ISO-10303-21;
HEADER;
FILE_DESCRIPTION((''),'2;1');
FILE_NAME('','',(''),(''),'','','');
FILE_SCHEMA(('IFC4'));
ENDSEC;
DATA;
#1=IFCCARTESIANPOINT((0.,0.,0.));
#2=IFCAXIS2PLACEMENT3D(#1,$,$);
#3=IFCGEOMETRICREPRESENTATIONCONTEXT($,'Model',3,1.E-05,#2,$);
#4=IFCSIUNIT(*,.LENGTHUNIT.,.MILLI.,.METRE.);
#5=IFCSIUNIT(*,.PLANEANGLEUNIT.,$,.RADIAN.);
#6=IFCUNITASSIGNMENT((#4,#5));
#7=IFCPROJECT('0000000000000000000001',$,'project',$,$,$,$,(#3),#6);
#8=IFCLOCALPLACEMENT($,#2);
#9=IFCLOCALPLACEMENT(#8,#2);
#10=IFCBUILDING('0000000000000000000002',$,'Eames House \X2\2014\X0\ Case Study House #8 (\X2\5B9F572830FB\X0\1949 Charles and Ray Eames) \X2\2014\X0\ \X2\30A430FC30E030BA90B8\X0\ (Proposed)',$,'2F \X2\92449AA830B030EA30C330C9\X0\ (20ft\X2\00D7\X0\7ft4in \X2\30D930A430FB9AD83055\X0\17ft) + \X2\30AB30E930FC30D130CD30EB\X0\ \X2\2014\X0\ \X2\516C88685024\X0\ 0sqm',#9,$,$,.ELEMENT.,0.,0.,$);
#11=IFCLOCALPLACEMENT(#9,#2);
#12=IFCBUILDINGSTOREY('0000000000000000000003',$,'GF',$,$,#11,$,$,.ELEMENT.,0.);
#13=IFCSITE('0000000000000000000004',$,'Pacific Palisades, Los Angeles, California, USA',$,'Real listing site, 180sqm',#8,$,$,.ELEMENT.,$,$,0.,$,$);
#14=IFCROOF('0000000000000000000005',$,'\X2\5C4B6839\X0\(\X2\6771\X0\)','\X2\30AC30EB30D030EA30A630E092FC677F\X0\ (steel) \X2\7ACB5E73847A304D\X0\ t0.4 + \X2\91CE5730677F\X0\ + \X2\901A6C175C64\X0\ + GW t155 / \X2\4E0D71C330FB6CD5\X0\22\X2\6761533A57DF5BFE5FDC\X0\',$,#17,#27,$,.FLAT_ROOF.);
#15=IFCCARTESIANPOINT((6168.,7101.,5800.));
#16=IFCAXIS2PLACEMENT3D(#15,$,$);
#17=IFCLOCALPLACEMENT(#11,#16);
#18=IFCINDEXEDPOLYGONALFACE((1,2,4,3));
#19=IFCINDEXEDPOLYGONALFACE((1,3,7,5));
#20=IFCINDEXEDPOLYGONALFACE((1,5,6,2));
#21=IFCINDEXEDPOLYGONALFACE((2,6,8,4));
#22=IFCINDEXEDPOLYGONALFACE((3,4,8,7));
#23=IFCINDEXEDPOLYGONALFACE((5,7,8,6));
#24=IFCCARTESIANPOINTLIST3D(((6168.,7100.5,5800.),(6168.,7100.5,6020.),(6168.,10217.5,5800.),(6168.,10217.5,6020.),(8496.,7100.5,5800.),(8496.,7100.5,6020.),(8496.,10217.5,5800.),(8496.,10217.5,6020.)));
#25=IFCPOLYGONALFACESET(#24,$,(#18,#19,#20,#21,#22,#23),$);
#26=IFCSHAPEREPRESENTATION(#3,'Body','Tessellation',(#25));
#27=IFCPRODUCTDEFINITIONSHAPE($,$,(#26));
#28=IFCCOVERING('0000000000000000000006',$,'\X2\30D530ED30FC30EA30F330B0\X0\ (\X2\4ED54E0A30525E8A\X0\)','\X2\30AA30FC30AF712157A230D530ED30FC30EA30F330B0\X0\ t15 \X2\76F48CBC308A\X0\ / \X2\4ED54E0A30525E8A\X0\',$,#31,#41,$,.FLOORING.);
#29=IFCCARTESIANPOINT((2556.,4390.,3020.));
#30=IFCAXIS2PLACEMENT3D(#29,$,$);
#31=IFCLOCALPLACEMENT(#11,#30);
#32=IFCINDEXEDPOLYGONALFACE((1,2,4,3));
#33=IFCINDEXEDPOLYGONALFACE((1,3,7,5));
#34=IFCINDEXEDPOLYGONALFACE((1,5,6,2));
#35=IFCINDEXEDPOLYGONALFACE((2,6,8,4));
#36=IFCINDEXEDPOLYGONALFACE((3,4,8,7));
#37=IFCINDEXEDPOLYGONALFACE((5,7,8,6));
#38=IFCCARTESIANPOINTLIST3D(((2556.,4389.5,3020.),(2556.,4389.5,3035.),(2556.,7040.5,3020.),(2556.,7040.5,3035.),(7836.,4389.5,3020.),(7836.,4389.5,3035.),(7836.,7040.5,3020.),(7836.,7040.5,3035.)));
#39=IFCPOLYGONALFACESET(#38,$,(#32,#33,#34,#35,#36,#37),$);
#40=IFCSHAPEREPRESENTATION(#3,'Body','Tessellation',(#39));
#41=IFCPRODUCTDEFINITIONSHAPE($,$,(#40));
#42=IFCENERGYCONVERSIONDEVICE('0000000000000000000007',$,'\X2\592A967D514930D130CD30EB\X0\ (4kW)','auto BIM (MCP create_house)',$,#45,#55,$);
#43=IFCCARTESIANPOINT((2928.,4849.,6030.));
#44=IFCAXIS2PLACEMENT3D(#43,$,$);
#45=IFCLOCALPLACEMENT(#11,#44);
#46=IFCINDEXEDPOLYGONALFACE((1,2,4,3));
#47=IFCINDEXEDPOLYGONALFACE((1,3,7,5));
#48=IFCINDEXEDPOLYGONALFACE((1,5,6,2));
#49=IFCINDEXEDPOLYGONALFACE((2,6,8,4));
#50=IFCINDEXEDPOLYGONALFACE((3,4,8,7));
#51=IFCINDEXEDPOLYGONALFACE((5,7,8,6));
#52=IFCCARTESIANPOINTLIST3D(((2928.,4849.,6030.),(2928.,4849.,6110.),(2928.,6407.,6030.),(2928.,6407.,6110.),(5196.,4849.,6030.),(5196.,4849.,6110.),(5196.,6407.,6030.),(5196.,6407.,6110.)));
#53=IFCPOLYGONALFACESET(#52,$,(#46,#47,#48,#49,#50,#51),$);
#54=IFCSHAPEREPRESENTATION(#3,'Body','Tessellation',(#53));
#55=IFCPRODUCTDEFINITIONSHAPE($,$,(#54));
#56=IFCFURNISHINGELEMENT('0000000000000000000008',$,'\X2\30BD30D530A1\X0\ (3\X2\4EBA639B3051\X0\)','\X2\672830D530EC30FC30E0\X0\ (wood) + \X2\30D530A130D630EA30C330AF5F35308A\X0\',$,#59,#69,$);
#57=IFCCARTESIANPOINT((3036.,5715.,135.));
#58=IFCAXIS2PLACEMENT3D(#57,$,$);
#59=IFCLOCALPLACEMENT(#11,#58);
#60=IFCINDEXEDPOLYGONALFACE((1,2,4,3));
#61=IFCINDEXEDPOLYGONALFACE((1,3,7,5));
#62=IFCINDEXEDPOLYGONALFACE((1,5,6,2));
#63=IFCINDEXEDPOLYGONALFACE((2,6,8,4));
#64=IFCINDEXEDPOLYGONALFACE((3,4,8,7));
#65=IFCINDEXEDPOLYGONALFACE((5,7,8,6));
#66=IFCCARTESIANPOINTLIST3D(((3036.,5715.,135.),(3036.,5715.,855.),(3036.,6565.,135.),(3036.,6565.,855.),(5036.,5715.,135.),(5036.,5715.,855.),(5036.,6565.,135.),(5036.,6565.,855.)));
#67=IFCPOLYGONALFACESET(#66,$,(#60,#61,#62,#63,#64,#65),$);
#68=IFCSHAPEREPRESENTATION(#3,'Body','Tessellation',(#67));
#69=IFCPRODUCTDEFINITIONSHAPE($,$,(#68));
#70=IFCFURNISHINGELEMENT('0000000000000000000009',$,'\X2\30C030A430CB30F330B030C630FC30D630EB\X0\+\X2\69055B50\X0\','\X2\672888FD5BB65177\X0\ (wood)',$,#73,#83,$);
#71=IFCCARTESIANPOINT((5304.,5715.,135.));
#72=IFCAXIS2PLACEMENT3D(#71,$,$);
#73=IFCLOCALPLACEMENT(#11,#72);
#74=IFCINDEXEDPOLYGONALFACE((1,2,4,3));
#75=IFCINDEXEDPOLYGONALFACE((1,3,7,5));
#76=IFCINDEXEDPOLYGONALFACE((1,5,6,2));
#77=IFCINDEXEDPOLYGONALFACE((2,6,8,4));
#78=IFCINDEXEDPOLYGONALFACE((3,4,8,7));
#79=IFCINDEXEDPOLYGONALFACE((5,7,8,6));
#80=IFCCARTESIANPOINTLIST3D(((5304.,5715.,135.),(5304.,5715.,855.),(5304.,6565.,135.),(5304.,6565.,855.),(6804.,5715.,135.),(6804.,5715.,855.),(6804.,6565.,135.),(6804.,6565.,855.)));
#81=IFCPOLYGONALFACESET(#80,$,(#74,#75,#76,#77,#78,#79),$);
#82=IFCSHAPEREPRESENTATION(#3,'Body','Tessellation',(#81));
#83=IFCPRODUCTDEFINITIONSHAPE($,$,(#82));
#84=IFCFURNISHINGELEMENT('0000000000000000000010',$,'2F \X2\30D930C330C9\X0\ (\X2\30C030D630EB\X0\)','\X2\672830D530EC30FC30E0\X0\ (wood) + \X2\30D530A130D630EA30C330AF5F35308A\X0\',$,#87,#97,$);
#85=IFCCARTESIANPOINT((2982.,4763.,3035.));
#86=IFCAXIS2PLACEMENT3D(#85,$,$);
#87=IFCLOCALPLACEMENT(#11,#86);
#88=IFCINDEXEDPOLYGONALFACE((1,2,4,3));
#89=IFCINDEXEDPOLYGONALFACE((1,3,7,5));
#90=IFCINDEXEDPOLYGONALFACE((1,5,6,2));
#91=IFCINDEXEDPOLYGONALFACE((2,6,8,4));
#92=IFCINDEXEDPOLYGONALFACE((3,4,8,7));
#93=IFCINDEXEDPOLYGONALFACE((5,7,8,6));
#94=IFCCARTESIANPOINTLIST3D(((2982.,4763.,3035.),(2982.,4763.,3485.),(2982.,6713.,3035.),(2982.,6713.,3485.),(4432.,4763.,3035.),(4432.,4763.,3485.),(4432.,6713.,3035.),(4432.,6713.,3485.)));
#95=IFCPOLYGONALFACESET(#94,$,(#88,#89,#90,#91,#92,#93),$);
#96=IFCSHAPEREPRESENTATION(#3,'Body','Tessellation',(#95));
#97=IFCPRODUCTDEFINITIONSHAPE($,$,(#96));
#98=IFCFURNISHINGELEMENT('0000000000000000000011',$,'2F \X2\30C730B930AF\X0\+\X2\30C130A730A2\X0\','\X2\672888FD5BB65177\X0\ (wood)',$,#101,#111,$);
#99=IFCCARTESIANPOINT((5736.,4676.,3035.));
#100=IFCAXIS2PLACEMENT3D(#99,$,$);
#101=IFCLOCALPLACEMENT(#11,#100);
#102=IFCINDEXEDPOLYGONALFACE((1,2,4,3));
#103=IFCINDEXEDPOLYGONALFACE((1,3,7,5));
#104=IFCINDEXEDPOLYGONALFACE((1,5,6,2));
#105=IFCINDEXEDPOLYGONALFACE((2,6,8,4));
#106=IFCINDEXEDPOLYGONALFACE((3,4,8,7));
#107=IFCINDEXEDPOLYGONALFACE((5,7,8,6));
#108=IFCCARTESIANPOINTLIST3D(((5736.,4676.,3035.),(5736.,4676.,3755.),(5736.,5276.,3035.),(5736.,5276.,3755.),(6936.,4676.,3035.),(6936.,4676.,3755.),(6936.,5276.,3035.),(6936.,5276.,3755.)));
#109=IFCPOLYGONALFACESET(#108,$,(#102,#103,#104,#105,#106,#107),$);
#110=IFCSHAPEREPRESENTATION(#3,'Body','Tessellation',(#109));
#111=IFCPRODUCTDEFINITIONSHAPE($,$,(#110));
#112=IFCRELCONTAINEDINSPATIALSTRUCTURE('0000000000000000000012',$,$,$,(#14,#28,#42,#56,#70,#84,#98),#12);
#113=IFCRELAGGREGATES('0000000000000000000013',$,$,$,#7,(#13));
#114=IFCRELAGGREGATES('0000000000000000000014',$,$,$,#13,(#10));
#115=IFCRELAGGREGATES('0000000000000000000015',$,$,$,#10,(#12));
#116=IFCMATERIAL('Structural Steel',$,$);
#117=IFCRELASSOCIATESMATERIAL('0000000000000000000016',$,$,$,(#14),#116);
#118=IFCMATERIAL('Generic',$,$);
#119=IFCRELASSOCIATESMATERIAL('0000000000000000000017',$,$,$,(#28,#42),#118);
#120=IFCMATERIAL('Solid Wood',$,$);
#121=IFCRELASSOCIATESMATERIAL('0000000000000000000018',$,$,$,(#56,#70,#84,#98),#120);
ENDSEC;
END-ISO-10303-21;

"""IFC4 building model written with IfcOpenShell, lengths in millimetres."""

from ifc_helpers import new_model, si_unit, frame, frame_2d, origin, place, context, project, spatial, rectangle, extrude, material, element, save


model = new_model("IFC4")

# Units and contexts
model_context = context("Model", 3, precision=1e-05, world=origin())
ifc_project = project(units=[si_unit("LENGTHUNIT", "METRE", prefix="MILLI"), si_unit("PLANEANGLEUNIT", "RADIAN")], contexts=[model_context])

# Site, building, storey
site_placement = place(None, origin())
site = spatial("IfcSite", under=ifc_project, at=site_placement, Name="Pacific Palisades, Los Angeles, California, USA", ObjectType="Real listing site, 180sqm", CompositionType="ELEMENT", RefElevation=0.0)
building_placement = place(site_placement, origin())
building = spatial("IfcBuilding", under=site, at=building_placement, Name="Eames House — Case Study House #8 (実在・1949 Charles and Ray Eames) — イームズ邸 (Proposed)", ObjectType="2F 鉄骨グリッド (20ft×7ft4in ベイ・高さ17ft) + カラーパネル — 公表値 0sqm", CompositionType="ELEMENT", ElevationOfRefHeight=0.0, ElevationOfTerrain=0.0)
storey_placement = place(building_placement, origin())
storey = spatial("IfcBuildingStorey", under=building, at=storey_placement, Name="GF", CompositionType="ELEMENT", Elevation=0.0)

# Shared definitions
ifc_material_1 = material(Name="Solid Wood")

# Roof
ifc_material_2 = material(Name="Structural Steel")
roof_1_placement = place(storey_placement, frame((6168.0, 7101.0, 5800.0)))
element("IfcRoof", 1, at=roof_1_placement, inside=storey, material=ifc_material_2, Name="屋根(東)", Description="ガルバリウム鋼板 (steel) 立平葺き t0.4 + 野地板 + 通気層 + GW t155 / 不燃・法22条区域対応", PredefinedType="FLAT_ROOF", context=model_context, shape_type="SweptSolid", body=[
    extrude(rectangle(XDim=2328.0, YDim=3117.0, at=frame_2d((1164.0, 1558.0))), frame((6168.0, 7101.0, 5800.0)), (0.0, 0.0, 1.0), 220.0),
])

# Covering
ifc_material_3 = material(Name="Generic")
covering_placement = place(storey_placement, frame((2556.0, 4390.0, 3020.0)))
element("IfcCovering", 2, at=covering_placement, inside=storey, material=ifc_material_3, Name="フローリング (仕上げ床)", Description="オーク無垢フローリング t15 直貼り / 仕上げ床", PredefinedType="FLOORING", context=model_context, shape_type="SweptSolid", body=[
    extrude(rectangle(XDim=5280.0, YDim=2651.0, at=frame_2d((2640.0, 1325.0))), frame((2556.0, 4390.0, 3020.0)), (0.0, 0.0, 1.0), 15.0),
])

# Energy conversion device
energy_conversion_device_placement = place(storey_placement, frame((2928.0, 4849.0, 6030.0)))
element("IfcEnergyConversionDevice", 3, at=energy_conversion_device_placement, inside=storey, material=ifc_material_3, Name="太陽光パネル (4kW)", Description="auto BIM (MCP create_house)", context=model_context, shape_type="SweptSolid", body=[
    extrude(rectangle(XDim=2268.0, YDim=1558.0, at=frame_2d((1134.0, 779.0))), frame((2928.0, 4849.0, 6030.0)), (0.0, 0.0, 1.0), 80.0),
])

# Furnishing elements
furnishing_1_placement = place(storey_placement, frame((3036.0, 5715.0, 135.0)))
element("IfcFurnishingElement", 4, at=furnishing_1_placement, inside=storey, material=ifc_material_1, Name="ソファ (3人掛け)", Description="木フレーム (wood) + ファブリック張り", context=model_context, shape_type="SweptSolid", body=[
    extrude(rectangle(XDim=2000.0, YDim=850.0, at=frame_2d((1000.0, 425.0))), frame((3036.0, 5715.0, 135.0)), (0.0, 0.0, 1.0), 720.0),
])
furnishing_2_placement = place(storey_placement, frame((5304.0, 5715.0, 135.0)))
element("IfcFurnishingElement", 5, at=furnishing_2_placement, inside=storey, material=ifc_material_1, Name="ダイニングテーブル+椅子", Description="木製家具 (wood)", context=model_context, shape_type="SweptSolid", body=[
    extrude(rectangle(XDim=1500.0, YDim=850.0, at=frame_2d((750.0, 425.0))), frame((5304.0, 5715.0, 135.0)), (0.0, 0.0, 1.0), 720.0),
])
furnishing_3_placement = place(storey_placement, frame((2982.0, 4763.0, 3035.0)))
element("IfcFurnishingElement", 6, at=furnishing_3_placement, inside=storey, material=ifc_material_1, Name="2F ベッド (ダブル)", Description="木フレーム (wood) + ファブリック張り", context=model_context, shape_type="SweptSolid", body=[
    extrude(rectangle(XDim=1450.0, YDim=1950.0, at=frame_2d((725.0, 975.0))), frame((2982.0, 4763.0, 3035.0)), (0.0, 0.0, 1.0), 450.0),
])
furnishing_4_placement = place(storey_placement, frame((5736.0, 4676.0, 3035.0)))
element("IfcFurnishingElement", 7, at=furnishing_4_placement, inside=storey, material=ifc_material_1, Name="2F デスク+チェア", Description="木製家具 (wood)", context=model_context, shape_type="SweptSolid", body=[
    extrude(rectangle(XDim=1200.0, YDim=600.0, at=frame_2d((600.0, 300.0))), frame((5736.0, 4676.0, 3035.0)), (0.0, 0.0, 1.0), 720.0),
])

save(model, "model.ifc")
